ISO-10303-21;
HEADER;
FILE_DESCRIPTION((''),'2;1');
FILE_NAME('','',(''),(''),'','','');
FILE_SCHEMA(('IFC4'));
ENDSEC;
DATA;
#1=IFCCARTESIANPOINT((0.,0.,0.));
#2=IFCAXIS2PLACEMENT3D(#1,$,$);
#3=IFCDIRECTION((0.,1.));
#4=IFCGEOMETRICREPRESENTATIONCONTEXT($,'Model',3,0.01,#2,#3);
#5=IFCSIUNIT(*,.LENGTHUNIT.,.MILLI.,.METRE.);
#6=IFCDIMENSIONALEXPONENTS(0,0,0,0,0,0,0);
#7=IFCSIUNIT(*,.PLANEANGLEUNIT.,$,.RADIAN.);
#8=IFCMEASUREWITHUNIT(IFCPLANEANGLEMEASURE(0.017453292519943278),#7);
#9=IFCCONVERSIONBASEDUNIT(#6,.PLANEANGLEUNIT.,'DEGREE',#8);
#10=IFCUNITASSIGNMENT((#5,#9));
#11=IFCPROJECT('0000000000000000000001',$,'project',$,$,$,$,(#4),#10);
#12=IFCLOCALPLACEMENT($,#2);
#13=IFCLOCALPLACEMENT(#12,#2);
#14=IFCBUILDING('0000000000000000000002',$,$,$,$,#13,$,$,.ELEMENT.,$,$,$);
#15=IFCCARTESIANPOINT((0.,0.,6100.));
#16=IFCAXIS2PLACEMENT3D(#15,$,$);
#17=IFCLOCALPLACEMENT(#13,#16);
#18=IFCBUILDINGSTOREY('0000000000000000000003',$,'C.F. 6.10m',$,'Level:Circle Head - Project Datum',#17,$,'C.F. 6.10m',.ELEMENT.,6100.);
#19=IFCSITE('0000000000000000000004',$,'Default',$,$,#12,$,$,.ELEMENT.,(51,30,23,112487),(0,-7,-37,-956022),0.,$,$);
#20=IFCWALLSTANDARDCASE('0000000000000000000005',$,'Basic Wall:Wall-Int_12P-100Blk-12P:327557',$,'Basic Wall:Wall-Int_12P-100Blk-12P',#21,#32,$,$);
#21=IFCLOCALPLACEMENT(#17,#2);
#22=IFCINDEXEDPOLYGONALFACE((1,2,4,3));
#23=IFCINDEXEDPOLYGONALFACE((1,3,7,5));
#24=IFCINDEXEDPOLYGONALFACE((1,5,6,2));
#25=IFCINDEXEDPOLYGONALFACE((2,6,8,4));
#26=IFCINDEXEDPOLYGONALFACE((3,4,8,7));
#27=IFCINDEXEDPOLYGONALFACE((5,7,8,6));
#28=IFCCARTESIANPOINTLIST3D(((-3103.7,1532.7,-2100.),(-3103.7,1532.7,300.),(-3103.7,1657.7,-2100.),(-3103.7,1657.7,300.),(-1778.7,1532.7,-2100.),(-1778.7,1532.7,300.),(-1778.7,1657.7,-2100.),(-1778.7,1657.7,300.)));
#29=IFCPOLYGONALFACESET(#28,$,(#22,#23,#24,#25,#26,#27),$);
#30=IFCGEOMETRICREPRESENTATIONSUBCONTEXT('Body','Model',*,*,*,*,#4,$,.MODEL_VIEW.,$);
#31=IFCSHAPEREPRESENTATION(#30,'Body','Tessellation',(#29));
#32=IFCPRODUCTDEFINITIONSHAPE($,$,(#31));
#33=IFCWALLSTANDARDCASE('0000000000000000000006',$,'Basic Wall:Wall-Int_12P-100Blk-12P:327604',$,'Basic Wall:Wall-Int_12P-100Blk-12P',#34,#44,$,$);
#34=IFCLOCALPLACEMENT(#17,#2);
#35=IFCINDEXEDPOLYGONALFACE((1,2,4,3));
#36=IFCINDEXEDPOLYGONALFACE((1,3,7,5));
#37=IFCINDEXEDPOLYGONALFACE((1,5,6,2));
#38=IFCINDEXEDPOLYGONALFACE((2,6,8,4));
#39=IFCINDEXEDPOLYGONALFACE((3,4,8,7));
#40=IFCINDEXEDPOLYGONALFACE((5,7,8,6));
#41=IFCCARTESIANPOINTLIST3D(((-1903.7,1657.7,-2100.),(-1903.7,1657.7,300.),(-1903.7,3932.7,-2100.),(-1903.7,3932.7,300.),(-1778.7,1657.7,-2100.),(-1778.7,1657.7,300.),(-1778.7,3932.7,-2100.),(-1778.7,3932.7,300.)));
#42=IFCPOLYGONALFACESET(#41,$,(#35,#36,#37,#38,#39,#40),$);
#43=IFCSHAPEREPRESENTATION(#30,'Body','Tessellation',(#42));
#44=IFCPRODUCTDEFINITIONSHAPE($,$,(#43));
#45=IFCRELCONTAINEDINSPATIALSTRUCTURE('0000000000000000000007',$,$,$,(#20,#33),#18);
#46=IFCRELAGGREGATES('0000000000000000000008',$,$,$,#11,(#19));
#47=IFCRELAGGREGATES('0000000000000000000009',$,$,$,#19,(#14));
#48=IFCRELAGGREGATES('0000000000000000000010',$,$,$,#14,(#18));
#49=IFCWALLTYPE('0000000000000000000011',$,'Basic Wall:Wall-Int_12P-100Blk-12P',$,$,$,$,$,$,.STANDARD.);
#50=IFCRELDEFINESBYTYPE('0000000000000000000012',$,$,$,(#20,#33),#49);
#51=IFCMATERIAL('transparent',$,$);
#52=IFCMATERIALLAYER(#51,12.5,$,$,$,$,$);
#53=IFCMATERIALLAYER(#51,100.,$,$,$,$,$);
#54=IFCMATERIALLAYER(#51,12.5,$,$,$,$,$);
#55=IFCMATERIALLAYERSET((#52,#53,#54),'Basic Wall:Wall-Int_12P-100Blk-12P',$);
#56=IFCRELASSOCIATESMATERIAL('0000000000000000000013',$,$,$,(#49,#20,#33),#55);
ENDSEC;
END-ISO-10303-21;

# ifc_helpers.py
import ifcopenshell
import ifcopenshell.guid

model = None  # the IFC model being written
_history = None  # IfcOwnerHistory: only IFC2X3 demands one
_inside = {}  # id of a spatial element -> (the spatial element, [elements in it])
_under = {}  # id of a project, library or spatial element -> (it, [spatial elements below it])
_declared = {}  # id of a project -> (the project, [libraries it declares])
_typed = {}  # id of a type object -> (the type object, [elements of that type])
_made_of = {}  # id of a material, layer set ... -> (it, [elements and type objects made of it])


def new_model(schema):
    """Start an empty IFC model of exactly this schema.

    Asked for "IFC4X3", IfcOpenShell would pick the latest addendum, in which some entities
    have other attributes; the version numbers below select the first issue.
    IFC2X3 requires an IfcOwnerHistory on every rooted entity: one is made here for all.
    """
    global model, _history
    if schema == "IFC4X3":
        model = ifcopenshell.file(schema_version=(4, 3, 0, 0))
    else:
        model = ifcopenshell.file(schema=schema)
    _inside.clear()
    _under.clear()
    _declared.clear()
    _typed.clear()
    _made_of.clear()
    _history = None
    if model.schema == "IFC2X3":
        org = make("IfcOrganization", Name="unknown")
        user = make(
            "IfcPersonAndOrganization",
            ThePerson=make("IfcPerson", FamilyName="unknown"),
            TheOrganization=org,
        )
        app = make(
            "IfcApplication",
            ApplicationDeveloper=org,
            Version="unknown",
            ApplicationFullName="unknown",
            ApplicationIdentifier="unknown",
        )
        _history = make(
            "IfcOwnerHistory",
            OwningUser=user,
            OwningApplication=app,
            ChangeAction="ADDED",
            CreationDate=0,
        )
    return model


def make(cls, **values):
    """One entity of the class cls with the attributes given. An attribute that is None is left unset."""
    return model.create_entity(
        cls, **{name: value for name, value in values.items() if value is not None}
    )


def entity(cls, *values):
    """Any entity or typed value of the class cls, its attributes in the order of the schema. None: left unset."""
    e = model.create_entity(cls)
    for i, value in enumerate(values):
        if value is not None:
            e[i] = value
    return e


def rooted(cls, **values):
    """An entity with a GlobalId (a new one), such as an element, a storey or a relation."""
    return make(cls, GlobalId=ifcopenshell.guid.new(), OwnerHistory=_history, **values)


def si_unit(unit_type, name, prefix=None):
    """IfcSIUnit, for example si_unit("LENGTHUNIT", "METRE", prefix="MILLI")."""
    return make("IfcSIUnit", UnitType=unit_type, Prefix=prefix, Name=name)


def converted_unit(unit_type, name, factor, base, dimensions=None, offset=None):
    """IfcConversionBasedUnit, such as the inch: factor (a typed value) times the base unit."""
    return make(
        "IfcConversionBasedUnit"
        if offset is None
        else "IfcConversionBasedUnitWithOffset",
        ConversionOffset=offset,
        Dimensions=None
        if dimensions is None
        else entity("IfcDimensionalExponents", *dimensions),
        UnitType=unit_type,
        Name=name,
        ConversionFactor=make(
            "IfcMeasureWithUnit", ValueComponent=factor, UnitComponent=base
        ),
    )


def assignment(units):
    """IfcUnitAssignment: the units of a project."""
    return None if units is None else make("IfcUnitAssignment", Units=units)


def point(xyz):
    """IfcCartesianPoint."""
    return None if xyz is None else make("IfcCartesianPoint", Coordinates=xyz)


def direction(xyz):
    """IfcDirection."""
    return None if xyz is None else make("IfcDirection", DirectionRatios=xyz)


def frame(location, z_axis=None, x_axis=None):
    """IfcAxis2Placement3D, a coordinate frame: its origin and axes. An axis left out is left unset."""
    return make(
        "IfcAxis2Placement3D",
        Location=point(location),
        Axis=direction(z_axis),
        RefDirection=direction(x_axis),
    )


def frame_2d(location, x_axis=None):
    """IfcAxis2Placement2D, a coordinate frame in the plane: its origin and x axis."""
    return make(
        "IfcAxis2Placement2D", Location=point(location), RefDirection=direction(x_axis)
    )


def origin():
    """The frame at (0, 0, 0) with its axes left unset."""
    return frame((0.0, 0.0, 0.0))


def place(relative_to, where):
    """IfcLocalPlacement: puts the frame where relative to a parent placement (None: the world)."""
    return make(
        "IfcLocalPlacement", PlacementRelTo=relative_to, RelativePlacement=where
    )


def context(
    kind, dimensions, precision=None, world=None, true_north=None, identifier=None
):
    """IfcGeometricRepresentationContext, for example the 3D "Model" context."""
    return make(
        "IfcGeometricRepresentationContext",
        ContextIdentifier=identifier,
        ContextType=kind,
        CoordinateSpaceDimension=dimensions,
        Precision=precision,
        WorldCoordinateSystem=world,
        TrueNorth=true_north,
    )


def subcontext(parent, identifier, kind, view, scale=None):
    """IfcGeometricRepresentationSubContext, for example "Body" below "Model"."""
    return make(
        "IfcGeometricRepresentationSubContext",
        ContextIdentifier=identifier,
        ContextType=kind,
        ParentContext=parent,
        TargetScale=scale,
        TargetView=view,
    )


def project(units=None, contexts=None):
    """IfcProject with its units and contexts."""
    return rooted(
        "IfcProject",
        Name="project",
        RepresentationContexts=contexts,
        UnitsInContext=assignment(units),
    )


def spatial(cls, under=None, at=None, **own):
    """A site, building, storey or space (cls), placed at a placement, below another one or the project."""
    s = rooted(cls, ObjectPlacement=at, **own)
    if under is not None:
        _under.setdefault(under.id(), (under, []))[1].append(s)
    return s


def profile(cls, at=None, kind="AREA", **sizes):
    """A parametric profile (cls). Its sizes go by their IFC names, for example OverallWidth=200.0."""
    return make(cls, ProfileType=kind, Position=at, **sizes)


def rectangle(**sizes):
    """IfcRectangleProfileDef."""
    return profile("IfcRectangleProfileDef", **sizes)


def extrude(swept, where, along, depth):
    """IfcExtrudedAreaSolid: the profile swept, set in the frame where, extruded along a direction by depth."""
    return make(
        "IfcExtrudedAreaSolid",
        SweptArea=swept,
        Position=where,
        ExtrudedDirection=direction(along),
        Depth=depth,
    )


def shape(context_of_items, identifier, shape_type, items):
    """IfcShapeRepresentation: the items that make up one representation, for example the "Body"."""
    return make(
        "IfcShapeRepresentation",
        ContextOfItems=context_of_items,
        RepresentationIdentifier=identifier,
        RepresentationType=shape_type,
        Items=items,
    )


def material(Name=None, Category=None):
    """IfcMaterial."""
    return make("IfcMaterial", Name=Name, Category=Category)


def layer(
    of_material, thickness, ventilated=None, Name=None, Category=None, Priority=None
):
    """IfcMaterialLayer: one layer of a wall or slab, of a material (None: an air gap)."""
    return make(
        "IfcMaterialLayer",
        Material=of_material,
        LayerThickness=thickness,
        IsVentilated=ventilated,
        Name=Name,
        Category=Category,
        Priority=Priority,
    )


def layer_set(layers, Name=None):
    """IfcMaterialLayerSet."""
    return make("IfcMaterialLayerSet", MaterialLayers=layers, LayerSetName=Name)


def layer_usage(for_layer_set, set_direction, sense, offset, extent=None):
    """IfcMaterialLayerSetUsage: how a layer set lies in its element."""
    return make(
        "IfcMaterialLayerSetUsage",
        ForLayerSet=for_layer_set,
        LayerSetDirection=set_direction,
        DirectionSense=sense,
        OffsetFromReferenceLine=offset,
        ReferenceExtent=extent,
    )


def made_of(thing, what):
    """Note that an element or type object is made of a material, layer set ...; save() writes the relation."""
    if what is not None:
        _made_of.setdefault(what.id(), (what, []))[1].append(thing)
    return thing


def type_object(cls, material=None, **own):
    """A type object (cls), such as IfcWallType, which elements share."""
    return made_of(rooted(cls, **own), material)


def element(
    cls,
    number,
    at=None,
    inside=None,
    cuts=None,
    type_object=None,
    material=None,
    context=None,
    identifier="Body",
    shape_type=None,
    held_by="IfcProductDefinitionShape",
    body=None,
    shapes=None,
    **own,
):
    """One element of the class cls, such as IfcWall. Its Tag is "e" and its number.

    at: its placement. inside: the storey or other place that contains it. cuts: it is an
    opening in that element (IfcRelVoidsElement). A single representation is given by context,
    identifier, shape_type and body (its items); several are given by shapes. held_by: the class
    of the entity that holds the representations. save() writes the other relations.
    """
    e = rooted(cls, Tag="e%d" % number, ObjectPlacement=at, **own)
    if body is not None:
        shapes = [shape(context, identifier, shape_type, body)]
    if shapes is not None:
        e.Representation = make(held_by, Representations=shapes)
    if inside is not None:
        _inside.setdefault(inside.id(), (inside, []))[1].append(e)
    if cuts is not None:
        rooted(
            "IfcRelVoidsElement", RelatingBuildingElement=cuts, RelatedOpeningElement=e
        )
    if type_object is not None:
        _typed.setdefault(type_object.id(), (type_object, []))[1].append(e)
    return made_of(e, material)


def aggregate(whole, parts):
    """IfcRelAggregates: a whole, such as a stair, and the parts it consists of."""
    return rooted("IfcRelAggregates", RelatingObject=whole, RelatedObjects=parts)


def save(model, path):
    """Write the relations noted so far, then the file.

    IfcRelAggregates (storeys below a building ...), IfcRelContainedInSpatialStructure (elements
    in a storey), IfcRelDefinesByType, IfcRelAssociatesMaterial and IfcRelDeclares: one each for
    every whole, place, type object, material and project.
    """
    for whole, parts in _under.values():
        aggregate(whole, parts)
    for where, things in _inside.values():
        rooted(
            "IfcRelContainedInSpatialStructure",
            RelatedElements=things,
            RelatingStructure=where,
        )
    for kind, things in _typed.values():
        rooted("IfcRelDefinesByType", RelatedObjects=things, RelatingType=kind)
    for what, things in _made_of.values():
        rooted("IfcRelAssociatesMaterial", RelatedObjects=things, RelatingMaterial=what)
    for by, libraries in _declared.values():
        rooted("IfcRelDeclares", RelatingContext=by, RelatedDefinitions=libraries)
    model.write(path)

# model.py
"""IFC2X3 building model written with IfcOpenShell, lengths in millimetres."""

from ifc_helpers import new_model, entity, si_unit, converted_unit, direction, frame, frame_2d, origin, place, context, subcontext, project, spatial, rectangle, extrude, material, layer, layer_set, layer_usage, type_object, element, save


model = new_model("IFC2X3")

# Units and contexts
model_context = context("Model", 3, precision=0.01, world=origin(), true_north=direction((0.0, 1.0)))
body_context = subcontext(model_context, "Body", "Model", "MODEL_VIEW")
ifc_project = project(units=[si_unit("LENGTHUNIT", "METRE", prefix="MILLI"), converted_unit("PLANEANGLEUNIT", "DEGREE", entity("IfcPlaneAngleMeasure", 0.017453292519943278), si_unit("PLANEANGLEUNIT", "RADIAN"), dimensions=[0, 0, 0, 0, 0, 0, 0])], contexts=[model_context])

# Site, building, storey
site_placement = place(None, origin())
site = spatial("IfcSite", under=ifc_project, at=site_placement, Name="Default", CompositionType="ELEMENT", RefLatitude=(51, 30, 23, 112487), RefLongitude=(0, -7, -37, -956022), RefElevation=0.0)
building_placement = place(site_placement, origin())
building = spatial("IfcBuilding", under=site, at=building_placement, CompositionType="ELEMENT")
storey_placement = place(building_placement, frame((0.0, 0.0, 6100.0)))
storey = spatial("IfcBuildingStorey", under=building, at=storey_placement, Name="C.F. 6.10m", ObjectType="Level:Circle Head - Project Datum", LongName="C.F. 6.10m", CompositionType="ELEMENT", Elevation=6100.0)

# Walls
ifc_material_1 = material(Name="transparent")
ifc_layer_1 = layer(ifc_material_1, 12.5)
ifc_layer_2 = layer(ifc_material_1, 100.0)
ifc_layer_3 = layer(ifc_material_1, 12.5)
ifc_layer_set_1 = layer_set([ifc_layer_1, ifc_layer_2, ifc_layer_3], Name="Basic Wall:Wall-Int_12P-100Blk-12P")
ifc_layer_usage_1 = layer_usage(ifc_layer_set_1, "AXIS2", "NEGATIVE", 62.5)
wall_type = type_object("IfcWallType", Name="Basic Wall:Wall-Int_12P-100Blk-12P", PredefinedType="STANDARD", material=ifc_layer_set_1)
wall_1_placement = place(storey_placement, frame((-3103.7, 1595.2, -2100.0)))
element("IfcWallStandardCase", 1, at=wall_1_placement, inside=storey, type_object=wall_type, material=ifc_layer_usage_1, Name="Basic Wall:Wall-Int_12P-100Blk-12P:327557", ObjectType="Basic Wall:Wall-Int_12P-100Blk-12P", context=body_context, shape_type="SweptSolid", body=[
    extrude(rectangle(XDim=1325.0, YDim=125.0, at=frame_2d((662.5, 0.0), x_axis=(-1.0, 0.0))), origin(), (0.0, 0.0, 1.0), 2400.0),
])
ifc_layer_usage_2 = layer_usage(ifc_layer_set_1, "AXIS2", "NEGATIVE", 62.5)
wall_2_placement = place(storey_placement, frame((-1841.2, 1657.7, -2100.0), z_axis=(0.0, 0.0, 1.0), x_axis=(0.0, 1.0, 0.0)))
element("IfcWallStandardCase", 2, at=wall_2_placement, inside=storey, type_object=wall_type, material=ifc_layer_usage_2, Name="Basic Wall:Wall-Int_12P-100Blk-12P:327604", ObjectType="Basic Wall:Wall-Int_12P-100Blk-12P", context=body_context, shape_type="SweptSolid", body=[
    extrude(rectangle(XDim=2275.0, YDim=125.0, at=frame_2d((1137.5, 0.0), x_axis=(-1.0, 0.0))), origin(), (0.0, 0.0, 1.0), 2400.0),
])

save(model, "model.ifc")
